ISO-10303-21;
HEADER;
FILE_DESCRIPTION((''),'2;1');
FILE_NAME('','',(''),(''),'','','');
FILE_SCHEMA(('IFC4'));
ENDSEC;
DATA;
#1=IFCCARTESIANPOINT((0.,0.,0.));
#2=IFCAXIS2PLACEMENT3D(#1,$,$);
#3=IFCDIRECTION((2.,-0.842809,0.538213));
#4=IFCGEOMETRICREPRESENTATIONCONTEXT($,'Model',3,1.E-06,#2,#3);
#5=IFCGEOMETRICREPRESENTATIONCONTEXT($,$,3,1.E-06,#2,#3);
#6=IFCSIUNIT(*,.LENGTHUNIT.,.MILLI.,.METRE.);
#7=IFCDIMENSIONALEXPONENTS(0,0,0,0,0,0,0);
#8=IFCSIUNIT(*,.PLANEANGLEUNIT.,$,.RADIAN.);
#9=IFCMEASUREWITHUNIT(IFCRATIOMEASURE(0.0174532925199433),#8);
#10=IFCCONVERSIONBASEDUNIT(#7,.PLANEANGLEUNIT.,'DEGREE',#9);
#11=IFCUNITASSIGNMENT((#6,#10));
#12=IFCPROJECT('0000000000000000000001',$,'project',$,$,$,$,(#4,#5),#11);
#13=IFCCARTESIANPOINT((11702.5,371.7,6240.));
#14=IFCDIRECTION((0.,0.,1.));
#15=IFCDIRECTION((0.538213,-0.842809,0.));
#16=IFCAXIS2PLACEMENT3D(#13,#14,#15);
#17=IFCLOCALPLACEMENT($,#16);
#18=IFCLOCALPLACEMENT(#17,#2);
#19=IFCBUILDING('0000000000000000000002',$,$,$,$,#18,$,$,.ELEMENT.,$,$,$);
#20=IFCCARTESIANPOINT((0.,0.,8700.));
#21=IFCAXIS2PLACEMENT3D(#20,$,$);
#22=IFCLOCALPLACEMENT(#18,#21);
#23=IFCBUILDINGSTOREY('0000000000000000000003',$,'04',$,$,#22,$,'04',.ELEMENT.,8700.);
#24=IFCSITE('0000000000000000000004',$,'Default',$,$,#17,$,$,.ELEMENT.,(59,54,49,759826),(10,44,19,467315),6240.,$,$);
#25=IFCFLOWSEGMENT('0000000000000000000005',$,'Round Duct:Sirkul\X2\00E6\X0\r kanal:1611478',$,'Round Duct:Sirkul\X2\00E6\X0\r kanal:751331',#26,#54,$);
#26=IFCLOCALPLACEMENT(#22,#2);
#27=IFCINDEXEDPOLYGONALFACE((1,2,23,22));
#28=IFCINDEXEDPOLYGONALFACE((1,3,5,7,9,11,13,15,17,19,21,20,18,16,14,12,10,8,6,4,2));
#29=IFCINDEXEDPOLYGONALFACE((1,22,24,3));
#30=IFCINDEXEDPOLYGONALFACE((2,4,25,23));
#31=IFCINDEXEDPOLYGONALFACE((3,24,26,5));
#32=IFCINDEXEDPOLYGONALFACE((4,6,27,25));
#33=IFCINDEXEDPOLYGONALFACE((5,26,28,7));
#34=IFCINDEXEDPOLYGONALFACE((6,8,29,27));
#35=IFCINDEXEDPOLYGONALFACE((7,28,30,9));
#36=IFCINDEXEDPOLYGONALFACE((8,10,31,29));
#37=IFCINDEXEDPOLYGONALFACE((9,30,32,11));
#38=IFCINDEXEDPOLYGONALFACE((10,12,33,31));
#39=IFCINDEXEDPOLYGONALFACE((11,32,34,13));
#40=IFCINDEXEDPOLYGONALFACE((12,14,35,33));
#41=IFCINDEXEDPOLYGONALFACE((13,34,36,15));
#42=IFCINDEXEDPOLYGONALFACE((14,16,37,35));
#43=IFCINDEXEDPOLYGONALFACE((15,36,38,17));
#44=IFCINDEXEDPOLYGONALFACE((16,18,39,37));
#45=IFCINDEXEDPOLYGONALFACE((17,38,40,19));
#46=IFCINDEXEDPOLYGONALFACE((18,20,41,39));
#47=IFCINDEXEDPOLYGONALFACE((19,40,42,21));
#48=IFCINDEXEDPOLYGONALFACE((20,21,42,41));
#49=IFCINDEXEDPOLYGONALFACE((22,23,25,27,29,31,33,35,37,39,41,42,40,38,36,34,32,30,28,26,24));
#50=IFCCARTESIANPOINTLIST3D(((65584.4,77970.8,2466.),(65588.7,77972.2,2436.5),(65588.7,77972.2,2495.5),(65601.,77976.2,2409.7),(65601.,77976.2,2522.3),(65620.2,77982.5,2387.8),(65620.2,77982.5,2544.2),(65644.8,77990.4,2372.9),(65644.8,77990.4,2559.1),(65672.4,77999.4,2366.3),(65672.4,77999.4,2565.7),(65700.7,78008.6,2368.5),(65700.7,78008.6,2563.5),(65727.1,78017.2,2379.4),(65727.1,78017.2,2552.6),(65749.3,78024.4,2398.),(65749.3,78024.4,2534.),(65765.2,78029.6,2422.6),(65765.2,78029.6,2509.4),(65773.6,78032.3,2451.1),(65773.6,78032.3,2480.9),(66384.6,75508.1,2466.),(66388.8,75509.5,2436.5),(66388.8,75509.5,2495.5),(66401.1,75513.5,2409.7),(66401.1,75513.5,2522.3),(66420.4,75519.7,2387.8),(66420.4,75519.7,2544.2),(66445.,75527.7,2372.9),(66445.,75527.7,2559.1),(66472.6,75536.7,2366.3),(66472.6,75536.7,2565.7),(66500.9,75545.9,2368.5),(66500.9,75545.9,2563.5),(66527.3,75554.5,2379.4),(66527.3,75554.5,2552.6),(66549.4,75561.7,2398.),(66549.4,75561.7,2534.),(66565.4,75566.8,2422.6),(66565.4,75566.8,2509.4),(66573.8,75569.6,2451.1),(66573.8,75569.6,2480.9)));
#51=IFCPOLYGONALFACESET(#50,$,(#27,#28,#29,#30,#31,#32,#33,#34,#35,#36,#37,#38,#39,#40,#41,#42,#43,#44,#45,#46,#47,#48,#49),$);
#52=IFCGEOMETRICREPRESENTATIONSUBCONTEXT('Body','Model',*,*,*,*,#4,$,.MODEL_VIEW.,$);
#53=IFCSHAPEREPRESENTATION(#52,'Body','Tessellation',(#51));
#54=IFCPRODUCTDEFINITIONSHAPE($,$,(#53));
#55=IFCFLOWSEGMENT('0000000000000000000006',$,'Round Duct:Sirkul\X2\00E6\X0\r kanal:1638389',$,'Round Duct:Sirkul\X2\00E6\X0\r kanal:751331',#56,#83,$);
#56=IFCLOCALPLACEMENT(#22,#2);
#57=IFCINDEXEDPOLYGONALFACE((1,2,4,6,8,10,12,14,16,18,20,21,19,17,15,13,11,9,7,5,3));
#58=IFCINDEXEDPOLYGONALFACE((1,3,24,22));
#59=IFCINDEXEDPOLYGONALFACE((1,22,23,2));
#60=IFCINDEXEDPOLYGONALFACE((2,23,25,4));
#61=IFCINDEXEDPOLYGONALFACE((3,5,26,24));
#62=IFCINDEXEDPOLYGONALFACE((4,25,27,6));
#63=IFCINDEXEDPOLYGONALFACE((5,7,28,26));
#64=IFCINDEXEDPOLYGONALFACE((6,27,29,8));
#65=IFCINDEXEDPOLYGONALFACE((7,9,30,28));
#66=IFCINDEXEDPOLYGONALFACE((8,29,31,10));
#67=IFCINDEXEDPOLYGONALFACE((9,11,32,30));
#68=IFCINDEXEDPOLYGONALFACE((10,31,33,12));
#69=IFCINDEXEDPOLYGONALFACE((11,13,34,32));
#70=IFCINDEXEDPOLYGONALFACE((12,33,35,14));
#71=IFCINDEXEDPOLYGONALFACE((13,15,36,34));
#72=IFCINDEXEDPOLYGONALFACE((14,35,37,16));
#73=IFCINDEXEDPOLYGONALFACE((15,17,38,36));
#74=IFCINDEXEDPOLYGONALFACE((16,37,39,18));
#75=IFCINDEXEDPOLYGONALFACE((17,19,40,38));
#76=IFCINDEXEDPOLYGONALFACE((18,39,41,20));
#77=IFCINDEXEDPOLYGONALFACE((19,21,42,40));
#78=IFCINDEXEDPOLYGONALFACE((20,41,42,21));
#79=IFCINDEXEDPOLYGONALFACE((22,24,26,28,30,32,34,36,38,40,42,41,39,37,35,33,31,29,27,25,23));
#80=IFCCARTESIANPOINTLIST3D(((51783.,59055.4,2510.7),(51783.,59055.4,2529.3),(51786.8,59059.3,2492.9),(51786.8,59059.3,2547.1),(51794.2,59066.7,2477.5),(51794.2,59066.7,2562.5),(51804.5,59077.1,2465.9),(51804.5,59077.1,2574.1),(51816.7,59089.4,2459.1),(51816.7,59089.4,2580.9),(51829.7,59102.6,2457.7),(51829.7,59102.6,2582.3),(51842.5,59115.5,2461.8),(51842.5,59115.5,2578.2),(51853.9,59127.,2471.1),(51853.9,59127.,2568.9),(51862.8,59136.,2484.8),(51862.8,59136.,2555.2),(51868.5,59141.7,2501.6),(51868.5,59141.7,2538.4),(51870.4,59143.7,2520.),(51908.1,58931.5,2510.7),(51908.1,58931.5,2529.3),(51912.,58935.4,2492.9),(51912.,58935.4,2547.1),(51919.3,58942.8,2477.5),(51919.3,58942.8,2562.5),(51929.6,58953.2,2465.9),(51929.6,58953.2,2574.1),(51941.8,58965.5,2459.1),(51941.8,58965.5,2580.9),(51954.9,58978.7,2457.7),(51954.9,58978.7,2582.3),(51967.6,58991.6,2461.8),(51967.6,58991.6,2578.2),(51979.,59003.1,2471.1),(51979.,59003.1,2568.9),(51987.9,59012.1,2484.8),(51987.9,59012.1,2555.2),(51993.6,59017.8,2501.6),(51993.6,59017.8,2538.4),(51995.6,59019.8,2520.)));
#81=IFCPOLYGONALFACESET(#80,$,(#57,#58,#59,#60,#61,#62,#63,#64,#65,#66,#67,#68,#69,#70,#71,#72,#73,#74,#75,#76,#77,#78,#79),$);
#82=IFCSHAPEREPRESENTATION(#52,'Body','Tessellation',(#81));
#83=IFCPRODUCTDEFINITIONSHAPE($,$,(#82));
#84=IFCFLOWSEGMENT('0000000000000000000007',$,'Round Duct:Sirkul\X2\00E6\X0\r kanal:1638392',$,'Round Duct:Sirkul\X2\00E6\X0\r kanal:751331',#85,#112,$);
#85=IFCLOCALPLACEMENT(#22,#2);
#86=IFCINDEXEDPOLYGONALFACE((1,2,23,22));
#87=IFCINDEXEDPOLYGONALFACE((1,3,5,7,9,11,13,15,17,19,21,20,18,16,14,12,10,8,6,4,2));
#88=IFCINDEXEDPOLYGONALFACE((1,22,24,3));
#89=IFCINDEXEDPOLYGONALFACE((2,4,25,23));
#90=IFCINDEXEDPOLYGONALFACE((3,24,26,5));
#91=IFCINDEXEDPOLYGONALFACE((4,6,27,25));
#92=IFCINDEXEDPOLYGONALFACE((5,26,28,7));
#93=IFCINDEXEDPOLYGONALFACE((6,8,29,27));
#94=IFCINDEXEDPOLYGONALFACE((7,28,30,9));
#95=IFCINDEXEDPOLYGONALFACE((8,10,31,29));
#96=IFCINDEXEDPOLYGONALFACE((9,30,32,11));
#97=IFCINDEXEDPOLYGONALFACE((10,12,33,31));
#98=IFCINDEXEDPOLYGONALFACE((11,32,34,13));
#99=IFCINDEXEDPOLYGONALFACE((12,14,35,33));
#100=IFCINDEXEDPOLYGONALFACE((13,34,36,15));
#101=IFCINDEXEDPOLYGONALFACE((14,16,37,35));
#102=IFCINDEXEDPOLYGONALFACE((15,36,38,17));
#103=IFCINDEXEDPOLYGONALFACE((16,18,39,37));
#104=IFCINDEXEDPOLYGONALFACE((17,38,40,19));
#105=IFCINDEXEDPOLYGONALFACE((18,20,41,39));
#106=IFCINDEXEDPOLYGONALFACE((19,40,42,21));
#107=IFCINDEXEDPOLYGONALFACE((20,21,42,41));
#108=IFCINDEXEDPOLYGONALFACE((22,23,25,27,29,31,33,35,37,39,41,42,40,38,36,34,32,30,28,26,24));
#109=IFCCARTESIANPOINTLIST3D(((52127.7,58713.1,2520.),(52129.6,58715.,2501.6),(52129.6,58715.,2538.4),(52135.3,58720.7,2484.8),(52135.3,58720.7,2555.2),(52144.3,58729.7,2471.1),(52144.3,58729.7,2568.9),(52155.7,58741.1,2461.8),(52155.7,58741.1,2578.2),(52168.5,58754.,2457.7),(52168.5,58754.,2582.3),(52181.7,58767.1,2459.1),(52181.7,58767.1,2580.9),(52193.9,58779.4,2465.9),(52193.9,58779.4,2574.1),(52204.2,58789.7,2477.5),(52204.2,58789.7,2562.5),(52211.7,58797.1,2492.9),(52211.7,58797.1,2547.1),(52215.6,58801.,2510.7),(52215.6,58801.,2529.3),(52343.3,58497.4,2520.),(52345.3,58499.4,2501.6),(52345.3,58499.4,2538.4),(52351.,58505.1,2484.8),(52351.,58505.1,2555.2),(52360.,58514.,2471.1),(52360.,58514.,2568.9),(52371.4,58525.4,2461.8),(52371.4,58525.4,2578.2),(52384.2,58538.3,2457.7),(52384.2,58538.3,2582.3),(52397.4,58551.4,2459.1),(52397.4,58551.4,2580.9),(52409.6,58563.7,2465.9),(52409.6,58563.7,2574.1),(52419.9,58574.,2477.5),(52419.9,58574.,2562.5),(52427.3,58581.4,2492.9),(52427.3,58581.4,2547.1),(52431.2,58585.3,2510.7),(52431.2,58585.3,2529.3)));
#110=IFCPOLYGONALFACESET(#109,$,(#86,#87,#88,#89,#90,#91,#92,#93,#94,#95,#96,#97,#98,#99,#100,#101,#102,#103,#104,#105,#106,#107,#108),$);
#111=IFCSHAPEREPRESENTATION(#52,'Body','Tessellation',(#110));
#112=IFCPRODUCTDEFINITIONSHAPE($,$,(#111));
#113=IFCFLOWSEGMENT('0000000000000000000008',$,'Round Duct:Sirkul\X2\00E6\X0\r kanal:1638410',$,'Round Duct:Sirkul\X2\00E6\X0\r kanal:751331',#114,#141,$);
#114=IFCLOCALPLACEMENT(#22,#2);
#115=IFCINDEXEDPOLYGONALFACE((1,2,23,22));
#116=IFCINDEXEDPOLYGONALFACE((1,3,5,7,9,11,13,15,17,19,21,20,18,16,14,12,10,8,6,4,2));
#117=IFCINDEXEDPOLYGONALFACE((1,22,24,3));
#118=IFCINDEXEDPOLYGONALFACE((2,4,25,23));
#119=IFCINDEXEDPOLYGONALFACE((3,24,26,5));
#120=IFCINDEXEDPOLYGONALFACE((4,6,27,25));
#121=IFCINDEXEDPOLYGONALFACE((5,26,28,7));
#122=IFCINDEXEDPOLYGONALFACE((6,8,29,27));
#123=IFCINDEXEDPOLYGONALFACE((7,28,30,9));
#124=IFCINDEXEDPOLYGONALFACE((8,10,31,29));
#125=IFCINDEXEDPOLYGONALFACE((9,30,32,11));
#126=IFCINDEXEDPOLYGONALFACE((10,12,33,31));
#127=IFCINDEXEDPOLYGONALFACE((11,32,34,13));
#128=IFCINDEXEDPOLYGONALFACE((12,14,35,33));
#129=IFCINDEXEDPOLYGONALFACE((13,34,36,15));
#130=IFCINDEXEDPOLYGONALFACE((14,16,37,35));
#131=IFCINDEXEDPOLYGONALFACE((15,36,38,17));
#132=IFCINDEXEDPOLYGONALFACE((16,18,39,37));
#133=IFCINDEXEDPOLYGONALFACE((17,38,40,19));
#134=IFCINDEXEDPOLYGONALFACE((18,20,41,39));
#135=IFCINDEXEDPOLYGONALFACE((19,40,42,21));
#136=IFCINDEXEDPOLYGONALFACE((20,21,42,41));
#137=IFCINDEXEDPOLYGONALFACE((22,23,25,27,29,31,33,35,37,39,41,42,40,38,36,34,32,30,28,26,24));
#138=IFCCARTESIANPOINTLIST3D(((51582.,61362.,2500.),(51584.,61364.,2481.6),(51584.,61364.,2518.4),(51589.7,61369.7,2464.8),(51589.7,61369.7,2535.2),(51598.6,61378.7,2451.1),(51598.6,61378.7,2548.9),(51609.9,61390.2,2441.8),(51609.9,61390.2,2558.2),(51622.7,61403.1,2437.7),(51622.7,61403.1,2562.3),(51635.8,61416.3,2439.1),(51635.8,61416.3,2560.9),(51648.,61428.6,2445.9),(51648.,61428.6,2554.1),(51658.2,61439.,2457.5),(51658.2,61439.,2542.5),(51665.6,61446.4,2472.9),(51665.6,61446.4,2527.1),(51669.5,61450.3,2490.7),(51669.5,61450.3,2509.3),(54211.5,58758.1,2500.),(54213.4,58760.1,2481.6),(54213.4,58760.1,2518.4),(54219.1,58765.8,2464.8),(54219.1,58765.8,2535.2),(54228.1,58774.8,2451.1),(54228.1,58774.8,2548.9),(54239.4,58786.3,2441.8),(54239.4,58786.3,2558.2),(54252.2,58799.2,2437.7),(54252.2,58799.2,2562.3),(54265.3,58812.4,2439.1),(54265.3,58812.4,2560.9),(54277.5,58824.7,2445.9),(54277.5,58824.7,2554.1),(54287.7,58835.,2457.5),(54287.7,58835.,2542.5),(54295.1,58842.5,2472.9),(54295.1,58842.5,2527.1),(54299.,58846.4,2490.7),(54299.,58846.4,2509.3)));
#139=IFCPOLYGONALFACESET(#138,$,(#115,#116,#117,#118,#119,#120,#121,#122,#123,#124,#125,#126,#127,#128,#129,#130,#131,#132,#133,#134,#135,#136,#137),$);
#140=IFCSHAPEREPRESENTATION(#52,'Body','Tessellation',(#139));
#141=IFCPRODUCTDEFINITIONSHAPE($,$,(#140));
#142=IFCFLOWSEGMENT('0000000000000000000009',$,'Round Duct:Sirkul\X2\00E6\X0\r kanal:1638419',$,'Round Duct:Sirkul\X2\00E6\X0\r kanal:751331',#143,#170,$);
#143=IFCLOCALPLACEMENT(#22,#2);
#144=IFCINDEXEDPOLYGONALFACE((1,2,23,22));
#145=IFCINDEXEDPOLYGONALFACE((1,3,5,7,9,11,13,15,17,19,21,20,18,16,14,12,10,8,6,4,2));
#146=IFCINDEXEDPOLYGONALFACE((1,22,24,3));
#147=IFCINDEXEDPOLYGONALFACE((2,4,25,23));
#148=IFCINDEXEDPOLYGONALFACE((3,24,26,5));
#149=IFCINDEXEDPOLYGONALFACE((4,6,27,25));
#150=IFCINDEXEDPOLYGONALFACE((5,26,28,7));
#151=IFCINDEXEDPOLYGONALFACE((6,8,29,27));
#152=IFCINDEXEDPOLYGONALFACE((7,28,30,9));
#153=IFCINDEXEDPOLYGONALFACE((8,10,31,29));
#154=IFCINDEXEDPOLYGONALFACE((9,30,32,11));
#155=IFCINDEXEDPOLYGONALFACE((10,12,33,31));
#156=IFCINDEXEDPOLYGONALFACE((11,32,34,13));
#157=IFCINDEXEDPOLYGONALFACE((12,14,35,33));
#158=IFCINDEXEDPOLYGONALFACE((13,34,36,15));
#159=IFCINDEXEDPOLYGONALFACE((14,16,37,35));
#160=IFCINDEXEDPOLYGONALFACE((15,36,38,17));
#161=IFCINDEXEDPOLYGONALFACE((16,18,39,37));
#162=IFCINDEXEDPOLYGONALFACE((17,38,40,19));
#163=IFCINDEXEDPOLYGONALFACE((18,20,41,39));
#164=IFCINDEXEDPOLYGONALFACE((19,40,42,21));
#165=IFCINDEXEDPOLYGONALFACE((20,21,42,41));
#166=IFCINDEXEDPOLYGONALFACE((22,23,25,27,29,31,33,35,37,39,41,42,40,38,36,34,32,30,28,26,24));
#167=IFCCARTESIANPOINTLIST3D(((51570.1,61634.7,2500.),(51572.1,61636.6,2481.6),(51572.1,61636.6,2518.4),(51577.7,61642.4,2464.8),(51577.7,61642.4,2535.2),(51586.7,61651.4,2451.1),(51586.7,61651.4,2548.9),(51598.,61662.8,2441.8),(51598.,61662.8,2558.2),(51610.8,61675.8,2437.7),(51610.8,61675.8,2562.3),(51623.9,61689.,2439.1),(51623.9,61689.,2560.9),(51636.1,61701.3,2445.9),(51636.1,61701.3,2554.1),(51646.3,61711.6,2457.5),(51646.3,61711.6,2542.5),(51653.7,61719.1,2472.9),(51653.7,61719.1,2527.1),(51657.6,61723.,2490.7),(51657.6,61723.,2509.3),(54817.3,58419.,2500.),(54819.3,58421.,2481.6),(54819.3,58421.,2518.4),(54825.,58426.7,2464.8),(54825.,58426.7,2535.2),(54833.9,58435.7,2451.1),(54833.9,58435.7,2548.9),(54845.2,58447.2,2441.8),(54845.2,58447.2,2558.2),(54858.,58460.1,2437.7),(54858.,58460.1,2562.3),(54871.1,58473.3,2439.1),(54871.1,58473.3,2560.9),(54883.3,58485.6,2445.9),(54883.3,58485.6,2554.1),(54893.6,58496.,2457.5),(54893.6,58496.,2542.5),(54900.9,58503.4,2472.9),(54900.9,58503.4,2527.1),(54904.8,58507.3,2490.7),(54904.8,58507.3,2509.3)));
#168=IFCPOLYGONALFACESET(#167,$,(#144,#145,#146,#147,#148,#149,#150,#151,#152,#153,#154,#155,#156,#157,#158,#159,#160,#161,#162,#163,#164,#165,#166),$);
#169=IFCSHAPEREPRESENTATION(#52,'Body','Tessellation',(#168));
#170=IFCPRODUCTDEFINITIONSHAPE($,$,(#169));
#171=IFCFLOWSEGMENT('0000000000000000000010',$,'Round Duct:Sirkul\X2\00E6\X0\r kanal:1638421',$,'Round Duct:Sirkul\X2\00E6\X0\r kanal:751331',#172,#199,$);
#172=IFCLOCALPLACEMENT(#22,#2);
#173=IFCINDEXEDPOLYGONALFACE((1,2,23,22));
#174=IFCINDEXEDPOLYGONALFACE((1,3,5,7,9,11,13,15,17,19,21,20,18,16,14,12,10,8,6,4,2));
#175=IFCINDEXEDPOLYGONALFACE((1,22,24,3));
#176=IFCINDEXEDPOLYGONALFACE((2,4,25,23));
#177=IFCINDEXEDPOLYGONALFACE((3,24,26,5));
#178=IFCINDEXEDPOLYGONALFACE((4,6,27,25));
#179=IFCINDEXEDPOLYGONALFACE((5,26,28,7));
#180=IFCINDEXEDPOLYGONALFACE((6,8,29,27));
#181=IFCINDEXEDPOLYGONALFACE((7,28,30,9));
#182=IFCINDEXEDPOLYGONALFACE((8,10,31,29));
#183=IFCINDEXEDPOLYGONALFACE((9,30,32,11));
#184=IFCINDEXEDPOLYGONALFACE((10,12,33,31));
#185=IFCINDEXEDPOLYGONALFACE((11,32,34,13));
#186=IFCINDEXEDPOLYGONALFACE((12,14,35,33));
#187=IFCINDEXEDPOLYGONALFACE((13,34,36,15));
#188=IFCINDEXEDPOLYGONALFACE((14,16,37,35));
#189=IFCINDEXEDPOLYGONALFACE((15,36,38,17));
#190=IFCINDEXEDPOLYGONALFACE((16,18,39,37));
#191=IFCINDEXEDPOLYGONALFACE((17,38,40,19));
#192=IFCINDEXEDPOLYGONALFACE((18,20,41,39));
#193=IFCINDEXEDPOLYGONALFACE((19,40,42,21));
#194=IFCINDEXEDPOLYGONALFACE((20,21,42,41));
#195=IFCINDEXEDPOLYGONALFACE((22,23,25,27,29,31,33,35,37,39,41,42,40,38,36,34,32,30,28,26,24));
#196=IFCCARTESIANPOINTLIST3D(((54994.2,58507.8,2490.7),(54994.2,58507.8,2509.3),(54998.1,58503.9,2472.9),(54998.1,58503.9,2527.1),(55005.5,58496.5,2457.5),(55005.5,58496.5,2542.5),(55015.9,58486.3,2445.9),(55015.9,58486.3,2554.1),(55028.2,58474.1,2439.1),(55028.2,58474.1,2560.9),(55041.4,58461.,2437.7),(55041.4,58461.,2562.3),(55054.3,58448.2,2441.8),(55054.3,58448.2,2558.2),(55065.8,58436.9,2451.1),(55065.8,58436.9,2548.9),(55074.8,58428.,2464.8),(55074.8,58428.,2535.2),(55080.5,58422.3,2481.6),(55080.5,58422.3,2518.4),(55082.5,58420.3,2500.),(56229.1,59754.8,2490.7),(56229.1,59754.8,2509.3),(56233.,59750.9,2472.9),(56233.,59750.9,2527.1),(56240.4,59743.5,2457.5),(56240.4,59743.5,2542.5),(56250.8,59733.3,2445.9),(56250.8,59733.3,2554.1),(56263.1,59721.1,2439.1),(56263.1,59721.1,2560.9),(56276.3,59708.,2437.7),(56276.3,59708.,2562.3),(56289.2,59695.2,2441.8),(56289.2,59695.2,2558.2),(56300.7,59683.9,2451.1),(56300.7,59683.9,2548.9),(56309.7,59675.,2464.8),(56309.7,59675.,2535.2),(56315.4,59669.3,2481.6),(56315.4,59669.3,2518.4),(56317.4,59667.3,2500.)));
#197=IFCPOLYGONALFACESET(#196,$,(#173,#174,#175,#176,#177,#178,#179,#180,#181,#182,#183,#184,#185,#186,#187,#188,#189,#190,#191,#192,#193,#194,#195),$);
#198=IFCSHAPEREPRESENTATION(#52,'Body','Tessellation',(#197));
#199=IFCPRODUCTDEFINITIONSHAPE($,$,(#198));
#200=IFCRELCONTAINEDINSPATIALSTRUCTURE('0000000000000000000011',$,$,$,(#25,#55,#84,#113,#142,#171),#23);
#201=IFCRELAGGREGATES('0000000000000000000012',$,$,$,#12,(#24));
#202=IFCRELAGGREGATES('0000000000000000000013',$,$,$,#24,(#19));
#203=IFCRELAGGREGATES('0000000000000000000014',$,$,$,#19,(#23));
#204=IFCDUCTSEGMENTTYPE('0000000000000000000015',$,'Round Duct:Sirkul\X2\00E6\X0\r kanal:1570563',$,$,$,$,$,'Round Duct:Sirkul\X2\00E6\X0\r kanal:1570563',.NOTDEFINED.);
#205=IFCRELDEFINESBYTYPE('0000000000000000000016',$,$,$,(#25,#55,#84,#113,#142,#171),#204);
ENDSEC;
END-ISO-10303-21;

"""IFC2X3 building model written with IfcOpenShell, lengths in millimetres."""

from ifc_helpers import new_model, entity, si_unit, converted_unit, direction, frame, origin, origin_2d_with_axis, place, context, subcontext, project, spatial, circle, extrude, type_object, element, save


model = new_model("IFC2X3")

# Units and contexts
model_context = context("Model", 3, precision=1e-06, world=origin(), true_north=direction((2.0, -0.842809, 0.538213)))
context_of_model = context(None, 3, precision=1e-06, world=origin(), true_north=direction((2.0, -0.842809, 0.538213)))
body_context = subcontext(model_context, "Body", "Model", "MODEL_VIEW")
ifc_project = project(units=[si_unit("LENGTHUNIT", "METRE", prefix="MILLI"), converted_unit("PLANEANGLEUNIT", "DEGREE", entity("IfcRatioMeasure", 0.0174532925199433), si_unit("PLANEANGLEUNIT", "RADIAN"), dimensions=[0, 0, 0, 0, 0, 0, 0])], contexts=[model_context, context_of_model])

# Site, building, storey
site_placement = place(None, frame((11702.5, 371.7, 6240.0), z_axis=(0.0, 0.0, 1.0), x_axis=(0.538213, -0.842809, 0.0)))
site = spatial("IfcSite", under=ifc_project, at=site_placement, Name="Default", CompositionType="ELEMENT", RefLatitude=(59, 54, 49, 759826), RefLongitude=(10, 44, 19, 467315), RefElevation=6240.0)
building_placement = place(site_placement, origin())
building = spatial("IfcBuilding", under=site, at=building_placement, CompositionType="ELEMENT")
storey_placement = place(building_placement, frame((0.0, 0.0, 8700.0)))
storey = spatial("IfcBuildingStorey", under=building, at=storey_placement, Name="04", LongName="04", CompositionType="ELEMENT", Elevation=8700.0)

# Flow segments
duct_segment_type = type_object("IfcDuctSegmentType", Name="Round Duct:Sirkulær kanal:1570563", ElementType="Round Duct:Sirkulær kanal:1570563", PredefinedType="NOTDEFINED")
flow_segment_1_placement = place(storey_placement, origin())
element("IfcFlowSegment", 1, at=flow_segment_1_placement, inside=storey, type_object=duct_segment_type, Name="Round Duct:Sirkulær kanal:1611478", ObjectType="Round Duct:Sirkulær kanal:751331", context=body_context, shape_type="SweptSolid", body=[
    extrude(circle(Radius=100.0, at=origin_2d_with_axis()), frame((65679.5, 78001.7, 2466.0), z_axis=(0.309017, -0.951057, 0.0), x_axis=(-0.951057, -0.309017, 0.0)), (0.0, 0.0, 1.0), 2589.5),
])
flow_segment_2_placement = place(storey_placement, origin())
element("IfcFlowSegment", 2, at=flow_segment_2_placement, inside=storey, type_object=duct_segment_type, Name="Round Duct:Sirkulær kanal:1638389", ObjectType="Round Duct:Sirkulær kanal:751331", context=body_context, shape_type="SweptSolid", body=[
    extrude(circle(Radius=62.5, at=origin_2d_with_axis()), frame((51826.5, 59099.3, 2520.0), z_axis=(0.710554, -0.703643, 0.0), x_axis=(0.703643, 0.710554, 0.0)), (0.0, 0.0, 1.0), 176.1),
])
flow_segment_3_placement = place(storey_placement, origin())
element("IfcFlowSegment", 3, at=flow_segment_3_placement, inside=storey, type_object=duct_segment_type, Name="Round Duct:Sirkulær kanal:1638392", ObjectType="Round Duct:Sirkulær kanal:751331", context=body_context, shape_type="SweptSolid", body=[
    extrude(circle(Radius=62.5, at=origin_2d_with_axis()), frame((52171.9, 58757.3, 2520.0), z_axis=(0.707107, -0.707107, 0.0), x_axis=(-0.707107, -0.707107, 0.0)), (0.0, 0.0, 1.0), 305.0),
])
flow_segment_4_placement = place(storey_placement, origin())
element("IfcFlowSegment", 4, at=flow_segment_4_placement, inside=storey, type_object=duct_segment_type, Name="Round Duct:Sirkulær kanal:1638410", ObjectType="Round Duct:Sirkulær kanal:751331", context=body_context, shape_type="SweptSolid", body=[
    extrude(circle(Radius=62.5, at=origin_2d_with_axis()), frame((51626.0, 61406.4, 2500.0), z_axis=(0.710554, -0.703643, 0.0), x_axis=(-0.703643, -0.710554, 0.0)), (0.0, 0.0, 1.0), 3700.6),
])
flow_segment_5_placement = place(storey_placement, origin())
element("IfcFlowSegment", 5, at=flow_segment_5_placement, inside=storey, type_object=duct_segment_type, Name="Round Duct:Sirkulær kanal:1638419", ObjectType="Round Duct:Sirkulær kanal:751331", context=body_context, shape_type="SweptSolid", body=[
    extrude(circle(Radius=62.5, at=origin_2d_with_axis()), frame((54861.3, 58463.4, 2500.0), z_axis=(-0.710554, 0.703643, 0.0), x_axis=(-0.703643, -0.710554, 0.0)), (0.0, 0.0, 1.0), 4570.0),
])
flow_segment_6_placement = place(storey_placement, origin())
element("IfcFlowSegment", 6, at=flow_segment_6_placement, inside=storey, type_object=duct_segment_type, Name="Round Duct:Sirkulær kanal:1638421", ObjectType="Round Duct:Sirkulær kanal:751331", context=body_context, shape_type="SweptSolid", body=[
    extrude(circle(Radius=62.5, at=origin_2d_with_axis()), frame((55038.1, 58464.3, 2500.0), z_axis=(0.703643, 0.710554, 0.0), x_axis=(0.710554, -0.703643, 0.0)), (0.0, 0.0, 1.0), 1755.0),
])

save(model, "model.ifc")
